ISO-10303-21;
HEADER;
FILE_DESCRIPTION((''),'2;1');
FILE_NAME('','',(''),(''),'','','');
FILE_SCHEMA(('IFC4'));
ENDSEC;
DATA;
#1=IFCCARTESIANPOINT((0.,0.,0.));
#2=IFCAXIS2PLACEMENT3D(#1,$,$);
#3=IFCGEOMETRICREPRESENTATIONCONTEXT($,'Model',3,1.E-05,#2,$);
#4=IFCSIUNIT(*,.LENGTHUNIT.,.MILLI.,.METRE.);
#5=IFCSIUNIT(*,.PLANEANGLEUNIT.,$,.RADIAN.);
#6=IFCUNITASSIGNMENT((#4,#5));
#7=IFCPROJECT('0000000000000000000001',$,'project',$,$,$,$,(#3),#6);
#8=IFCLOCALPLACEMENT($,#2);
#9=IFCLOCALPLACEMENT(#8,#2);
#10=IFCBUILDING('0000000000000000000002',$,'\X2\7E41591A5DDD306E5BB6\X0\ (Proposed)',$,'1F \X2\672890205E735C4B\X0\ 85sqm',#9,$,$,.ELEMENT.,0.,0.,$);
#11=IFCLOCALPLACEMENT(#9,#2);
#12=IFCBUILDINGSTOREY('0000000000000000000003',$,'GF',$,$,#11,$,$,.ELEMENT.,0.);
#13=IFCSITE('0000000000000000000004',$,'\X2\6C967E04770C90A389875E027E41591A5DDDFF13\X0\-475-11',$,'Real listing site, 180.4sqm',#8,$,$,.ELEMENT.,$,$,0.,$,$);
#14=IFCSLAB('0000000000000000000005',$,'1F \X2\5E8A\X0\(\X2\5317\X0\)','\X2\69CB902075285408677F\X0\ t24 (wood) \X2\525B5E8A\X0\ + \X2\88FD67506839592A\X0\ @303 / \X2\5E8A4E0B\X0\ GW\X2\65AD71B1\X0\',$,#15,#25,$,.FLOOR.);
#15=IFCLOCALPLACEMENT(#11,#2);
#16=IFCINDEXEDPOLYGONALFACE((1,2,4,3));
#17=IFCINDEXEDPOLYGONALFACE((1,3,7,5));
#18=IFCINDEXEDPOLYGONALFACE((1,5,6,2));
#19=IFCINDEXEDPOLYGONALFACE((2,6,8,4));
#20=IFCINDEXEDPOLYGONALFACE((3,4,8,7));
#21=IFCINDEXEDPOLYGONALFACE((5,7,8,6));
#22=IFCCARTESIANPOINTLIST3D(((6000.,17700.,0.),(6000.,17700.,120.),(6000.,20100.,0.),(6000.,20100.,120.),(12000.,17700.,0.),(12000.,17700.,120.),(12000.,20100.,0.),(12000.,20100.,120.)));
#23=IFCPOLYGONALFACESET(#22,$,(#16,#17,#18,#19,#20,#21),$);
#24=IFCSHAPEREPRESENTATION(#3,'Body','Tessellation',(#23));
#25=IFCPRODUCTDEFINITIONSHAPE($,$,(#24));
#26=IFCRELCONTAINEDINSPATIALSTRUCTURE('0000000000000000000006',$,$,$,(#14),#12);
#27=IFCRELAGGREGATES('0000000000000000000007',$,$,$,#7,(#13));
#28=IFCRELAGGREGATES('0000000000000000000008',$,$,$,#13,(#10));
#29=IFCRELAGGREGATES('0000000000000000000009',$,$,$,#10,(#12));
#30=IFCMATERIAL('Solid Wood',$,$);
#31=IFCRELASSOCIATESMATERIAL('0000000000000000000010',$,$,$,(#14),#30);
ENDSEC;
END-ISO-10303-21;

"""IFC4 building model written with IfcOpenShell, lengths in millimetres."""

from ifc_helpers import new_model, si_unit, frame, frame_2d, origin, place, context, project, spatial, rectangle, extrude, material, element, save


model = new_model("IFC4")

# Units and contexts
model_context = context("Model", 3, precision=1e-05, world=origin())
ifc_project = project(units=[si_unit("LENGTHUNIT", "METRE", prefix="MILLI"), si_unit("PLANEANGLEUNIT", "RADIAN")], contexts=[model_context])

# Site, building, storey
site_placement = place(None, origin())
site = spatial("IfcSite", under=ifc_project, at=site_placement, Name="沖縄県那覇市繁多川３-475-11", ObjectType="Real listing site, 180.4sqm", CompositionType="ELEMENT", RefElevation=0.0)
building_placement = place(site_placement, origin())
building = spatial("IfcBuilding", under=site, at=building_placement, Name="繁多川の家 (Proposed)", ObjectType="1F 木造平屋 85sqm", CompositionType="ELEMENT", ElevationOfRefHeight=0.0, ElevationOfTerrain=0.0)
storey_placement = place(building_placement, origin())
storey = spatial("IfcBuildingStorey", under=building, at=storey_placement, Name="GF", CompositionType="ELEMENT", Elevation=0.0)

# Slab
ifc_material_1 = material(Name="Solid Wood")
slab_1_placement = place(storey_placement, frame((3000.0, 8850.0, 0.0)))
element("IfcSlab", 1, at=slab_1_placement, inside=storey, material=ifc_material_1, Name="1F 床(北)", Description="構造用合板 t24 (wood) 剛床 + 製材根太 @303 / 床下 GW断熱", PredefinedType="FLOOR", context=model_context, shape_type="SweptSolid", body=[
    extrude(rectangle(XDim=6000.0, YDim=2400.0, at=frame_2d((3000.0, 1200.0))), frame((3000.0, 8850.0, 0.0)), (0.0, 0.0, 1.0), 120.0),
])

save(model, "model.ifc")
